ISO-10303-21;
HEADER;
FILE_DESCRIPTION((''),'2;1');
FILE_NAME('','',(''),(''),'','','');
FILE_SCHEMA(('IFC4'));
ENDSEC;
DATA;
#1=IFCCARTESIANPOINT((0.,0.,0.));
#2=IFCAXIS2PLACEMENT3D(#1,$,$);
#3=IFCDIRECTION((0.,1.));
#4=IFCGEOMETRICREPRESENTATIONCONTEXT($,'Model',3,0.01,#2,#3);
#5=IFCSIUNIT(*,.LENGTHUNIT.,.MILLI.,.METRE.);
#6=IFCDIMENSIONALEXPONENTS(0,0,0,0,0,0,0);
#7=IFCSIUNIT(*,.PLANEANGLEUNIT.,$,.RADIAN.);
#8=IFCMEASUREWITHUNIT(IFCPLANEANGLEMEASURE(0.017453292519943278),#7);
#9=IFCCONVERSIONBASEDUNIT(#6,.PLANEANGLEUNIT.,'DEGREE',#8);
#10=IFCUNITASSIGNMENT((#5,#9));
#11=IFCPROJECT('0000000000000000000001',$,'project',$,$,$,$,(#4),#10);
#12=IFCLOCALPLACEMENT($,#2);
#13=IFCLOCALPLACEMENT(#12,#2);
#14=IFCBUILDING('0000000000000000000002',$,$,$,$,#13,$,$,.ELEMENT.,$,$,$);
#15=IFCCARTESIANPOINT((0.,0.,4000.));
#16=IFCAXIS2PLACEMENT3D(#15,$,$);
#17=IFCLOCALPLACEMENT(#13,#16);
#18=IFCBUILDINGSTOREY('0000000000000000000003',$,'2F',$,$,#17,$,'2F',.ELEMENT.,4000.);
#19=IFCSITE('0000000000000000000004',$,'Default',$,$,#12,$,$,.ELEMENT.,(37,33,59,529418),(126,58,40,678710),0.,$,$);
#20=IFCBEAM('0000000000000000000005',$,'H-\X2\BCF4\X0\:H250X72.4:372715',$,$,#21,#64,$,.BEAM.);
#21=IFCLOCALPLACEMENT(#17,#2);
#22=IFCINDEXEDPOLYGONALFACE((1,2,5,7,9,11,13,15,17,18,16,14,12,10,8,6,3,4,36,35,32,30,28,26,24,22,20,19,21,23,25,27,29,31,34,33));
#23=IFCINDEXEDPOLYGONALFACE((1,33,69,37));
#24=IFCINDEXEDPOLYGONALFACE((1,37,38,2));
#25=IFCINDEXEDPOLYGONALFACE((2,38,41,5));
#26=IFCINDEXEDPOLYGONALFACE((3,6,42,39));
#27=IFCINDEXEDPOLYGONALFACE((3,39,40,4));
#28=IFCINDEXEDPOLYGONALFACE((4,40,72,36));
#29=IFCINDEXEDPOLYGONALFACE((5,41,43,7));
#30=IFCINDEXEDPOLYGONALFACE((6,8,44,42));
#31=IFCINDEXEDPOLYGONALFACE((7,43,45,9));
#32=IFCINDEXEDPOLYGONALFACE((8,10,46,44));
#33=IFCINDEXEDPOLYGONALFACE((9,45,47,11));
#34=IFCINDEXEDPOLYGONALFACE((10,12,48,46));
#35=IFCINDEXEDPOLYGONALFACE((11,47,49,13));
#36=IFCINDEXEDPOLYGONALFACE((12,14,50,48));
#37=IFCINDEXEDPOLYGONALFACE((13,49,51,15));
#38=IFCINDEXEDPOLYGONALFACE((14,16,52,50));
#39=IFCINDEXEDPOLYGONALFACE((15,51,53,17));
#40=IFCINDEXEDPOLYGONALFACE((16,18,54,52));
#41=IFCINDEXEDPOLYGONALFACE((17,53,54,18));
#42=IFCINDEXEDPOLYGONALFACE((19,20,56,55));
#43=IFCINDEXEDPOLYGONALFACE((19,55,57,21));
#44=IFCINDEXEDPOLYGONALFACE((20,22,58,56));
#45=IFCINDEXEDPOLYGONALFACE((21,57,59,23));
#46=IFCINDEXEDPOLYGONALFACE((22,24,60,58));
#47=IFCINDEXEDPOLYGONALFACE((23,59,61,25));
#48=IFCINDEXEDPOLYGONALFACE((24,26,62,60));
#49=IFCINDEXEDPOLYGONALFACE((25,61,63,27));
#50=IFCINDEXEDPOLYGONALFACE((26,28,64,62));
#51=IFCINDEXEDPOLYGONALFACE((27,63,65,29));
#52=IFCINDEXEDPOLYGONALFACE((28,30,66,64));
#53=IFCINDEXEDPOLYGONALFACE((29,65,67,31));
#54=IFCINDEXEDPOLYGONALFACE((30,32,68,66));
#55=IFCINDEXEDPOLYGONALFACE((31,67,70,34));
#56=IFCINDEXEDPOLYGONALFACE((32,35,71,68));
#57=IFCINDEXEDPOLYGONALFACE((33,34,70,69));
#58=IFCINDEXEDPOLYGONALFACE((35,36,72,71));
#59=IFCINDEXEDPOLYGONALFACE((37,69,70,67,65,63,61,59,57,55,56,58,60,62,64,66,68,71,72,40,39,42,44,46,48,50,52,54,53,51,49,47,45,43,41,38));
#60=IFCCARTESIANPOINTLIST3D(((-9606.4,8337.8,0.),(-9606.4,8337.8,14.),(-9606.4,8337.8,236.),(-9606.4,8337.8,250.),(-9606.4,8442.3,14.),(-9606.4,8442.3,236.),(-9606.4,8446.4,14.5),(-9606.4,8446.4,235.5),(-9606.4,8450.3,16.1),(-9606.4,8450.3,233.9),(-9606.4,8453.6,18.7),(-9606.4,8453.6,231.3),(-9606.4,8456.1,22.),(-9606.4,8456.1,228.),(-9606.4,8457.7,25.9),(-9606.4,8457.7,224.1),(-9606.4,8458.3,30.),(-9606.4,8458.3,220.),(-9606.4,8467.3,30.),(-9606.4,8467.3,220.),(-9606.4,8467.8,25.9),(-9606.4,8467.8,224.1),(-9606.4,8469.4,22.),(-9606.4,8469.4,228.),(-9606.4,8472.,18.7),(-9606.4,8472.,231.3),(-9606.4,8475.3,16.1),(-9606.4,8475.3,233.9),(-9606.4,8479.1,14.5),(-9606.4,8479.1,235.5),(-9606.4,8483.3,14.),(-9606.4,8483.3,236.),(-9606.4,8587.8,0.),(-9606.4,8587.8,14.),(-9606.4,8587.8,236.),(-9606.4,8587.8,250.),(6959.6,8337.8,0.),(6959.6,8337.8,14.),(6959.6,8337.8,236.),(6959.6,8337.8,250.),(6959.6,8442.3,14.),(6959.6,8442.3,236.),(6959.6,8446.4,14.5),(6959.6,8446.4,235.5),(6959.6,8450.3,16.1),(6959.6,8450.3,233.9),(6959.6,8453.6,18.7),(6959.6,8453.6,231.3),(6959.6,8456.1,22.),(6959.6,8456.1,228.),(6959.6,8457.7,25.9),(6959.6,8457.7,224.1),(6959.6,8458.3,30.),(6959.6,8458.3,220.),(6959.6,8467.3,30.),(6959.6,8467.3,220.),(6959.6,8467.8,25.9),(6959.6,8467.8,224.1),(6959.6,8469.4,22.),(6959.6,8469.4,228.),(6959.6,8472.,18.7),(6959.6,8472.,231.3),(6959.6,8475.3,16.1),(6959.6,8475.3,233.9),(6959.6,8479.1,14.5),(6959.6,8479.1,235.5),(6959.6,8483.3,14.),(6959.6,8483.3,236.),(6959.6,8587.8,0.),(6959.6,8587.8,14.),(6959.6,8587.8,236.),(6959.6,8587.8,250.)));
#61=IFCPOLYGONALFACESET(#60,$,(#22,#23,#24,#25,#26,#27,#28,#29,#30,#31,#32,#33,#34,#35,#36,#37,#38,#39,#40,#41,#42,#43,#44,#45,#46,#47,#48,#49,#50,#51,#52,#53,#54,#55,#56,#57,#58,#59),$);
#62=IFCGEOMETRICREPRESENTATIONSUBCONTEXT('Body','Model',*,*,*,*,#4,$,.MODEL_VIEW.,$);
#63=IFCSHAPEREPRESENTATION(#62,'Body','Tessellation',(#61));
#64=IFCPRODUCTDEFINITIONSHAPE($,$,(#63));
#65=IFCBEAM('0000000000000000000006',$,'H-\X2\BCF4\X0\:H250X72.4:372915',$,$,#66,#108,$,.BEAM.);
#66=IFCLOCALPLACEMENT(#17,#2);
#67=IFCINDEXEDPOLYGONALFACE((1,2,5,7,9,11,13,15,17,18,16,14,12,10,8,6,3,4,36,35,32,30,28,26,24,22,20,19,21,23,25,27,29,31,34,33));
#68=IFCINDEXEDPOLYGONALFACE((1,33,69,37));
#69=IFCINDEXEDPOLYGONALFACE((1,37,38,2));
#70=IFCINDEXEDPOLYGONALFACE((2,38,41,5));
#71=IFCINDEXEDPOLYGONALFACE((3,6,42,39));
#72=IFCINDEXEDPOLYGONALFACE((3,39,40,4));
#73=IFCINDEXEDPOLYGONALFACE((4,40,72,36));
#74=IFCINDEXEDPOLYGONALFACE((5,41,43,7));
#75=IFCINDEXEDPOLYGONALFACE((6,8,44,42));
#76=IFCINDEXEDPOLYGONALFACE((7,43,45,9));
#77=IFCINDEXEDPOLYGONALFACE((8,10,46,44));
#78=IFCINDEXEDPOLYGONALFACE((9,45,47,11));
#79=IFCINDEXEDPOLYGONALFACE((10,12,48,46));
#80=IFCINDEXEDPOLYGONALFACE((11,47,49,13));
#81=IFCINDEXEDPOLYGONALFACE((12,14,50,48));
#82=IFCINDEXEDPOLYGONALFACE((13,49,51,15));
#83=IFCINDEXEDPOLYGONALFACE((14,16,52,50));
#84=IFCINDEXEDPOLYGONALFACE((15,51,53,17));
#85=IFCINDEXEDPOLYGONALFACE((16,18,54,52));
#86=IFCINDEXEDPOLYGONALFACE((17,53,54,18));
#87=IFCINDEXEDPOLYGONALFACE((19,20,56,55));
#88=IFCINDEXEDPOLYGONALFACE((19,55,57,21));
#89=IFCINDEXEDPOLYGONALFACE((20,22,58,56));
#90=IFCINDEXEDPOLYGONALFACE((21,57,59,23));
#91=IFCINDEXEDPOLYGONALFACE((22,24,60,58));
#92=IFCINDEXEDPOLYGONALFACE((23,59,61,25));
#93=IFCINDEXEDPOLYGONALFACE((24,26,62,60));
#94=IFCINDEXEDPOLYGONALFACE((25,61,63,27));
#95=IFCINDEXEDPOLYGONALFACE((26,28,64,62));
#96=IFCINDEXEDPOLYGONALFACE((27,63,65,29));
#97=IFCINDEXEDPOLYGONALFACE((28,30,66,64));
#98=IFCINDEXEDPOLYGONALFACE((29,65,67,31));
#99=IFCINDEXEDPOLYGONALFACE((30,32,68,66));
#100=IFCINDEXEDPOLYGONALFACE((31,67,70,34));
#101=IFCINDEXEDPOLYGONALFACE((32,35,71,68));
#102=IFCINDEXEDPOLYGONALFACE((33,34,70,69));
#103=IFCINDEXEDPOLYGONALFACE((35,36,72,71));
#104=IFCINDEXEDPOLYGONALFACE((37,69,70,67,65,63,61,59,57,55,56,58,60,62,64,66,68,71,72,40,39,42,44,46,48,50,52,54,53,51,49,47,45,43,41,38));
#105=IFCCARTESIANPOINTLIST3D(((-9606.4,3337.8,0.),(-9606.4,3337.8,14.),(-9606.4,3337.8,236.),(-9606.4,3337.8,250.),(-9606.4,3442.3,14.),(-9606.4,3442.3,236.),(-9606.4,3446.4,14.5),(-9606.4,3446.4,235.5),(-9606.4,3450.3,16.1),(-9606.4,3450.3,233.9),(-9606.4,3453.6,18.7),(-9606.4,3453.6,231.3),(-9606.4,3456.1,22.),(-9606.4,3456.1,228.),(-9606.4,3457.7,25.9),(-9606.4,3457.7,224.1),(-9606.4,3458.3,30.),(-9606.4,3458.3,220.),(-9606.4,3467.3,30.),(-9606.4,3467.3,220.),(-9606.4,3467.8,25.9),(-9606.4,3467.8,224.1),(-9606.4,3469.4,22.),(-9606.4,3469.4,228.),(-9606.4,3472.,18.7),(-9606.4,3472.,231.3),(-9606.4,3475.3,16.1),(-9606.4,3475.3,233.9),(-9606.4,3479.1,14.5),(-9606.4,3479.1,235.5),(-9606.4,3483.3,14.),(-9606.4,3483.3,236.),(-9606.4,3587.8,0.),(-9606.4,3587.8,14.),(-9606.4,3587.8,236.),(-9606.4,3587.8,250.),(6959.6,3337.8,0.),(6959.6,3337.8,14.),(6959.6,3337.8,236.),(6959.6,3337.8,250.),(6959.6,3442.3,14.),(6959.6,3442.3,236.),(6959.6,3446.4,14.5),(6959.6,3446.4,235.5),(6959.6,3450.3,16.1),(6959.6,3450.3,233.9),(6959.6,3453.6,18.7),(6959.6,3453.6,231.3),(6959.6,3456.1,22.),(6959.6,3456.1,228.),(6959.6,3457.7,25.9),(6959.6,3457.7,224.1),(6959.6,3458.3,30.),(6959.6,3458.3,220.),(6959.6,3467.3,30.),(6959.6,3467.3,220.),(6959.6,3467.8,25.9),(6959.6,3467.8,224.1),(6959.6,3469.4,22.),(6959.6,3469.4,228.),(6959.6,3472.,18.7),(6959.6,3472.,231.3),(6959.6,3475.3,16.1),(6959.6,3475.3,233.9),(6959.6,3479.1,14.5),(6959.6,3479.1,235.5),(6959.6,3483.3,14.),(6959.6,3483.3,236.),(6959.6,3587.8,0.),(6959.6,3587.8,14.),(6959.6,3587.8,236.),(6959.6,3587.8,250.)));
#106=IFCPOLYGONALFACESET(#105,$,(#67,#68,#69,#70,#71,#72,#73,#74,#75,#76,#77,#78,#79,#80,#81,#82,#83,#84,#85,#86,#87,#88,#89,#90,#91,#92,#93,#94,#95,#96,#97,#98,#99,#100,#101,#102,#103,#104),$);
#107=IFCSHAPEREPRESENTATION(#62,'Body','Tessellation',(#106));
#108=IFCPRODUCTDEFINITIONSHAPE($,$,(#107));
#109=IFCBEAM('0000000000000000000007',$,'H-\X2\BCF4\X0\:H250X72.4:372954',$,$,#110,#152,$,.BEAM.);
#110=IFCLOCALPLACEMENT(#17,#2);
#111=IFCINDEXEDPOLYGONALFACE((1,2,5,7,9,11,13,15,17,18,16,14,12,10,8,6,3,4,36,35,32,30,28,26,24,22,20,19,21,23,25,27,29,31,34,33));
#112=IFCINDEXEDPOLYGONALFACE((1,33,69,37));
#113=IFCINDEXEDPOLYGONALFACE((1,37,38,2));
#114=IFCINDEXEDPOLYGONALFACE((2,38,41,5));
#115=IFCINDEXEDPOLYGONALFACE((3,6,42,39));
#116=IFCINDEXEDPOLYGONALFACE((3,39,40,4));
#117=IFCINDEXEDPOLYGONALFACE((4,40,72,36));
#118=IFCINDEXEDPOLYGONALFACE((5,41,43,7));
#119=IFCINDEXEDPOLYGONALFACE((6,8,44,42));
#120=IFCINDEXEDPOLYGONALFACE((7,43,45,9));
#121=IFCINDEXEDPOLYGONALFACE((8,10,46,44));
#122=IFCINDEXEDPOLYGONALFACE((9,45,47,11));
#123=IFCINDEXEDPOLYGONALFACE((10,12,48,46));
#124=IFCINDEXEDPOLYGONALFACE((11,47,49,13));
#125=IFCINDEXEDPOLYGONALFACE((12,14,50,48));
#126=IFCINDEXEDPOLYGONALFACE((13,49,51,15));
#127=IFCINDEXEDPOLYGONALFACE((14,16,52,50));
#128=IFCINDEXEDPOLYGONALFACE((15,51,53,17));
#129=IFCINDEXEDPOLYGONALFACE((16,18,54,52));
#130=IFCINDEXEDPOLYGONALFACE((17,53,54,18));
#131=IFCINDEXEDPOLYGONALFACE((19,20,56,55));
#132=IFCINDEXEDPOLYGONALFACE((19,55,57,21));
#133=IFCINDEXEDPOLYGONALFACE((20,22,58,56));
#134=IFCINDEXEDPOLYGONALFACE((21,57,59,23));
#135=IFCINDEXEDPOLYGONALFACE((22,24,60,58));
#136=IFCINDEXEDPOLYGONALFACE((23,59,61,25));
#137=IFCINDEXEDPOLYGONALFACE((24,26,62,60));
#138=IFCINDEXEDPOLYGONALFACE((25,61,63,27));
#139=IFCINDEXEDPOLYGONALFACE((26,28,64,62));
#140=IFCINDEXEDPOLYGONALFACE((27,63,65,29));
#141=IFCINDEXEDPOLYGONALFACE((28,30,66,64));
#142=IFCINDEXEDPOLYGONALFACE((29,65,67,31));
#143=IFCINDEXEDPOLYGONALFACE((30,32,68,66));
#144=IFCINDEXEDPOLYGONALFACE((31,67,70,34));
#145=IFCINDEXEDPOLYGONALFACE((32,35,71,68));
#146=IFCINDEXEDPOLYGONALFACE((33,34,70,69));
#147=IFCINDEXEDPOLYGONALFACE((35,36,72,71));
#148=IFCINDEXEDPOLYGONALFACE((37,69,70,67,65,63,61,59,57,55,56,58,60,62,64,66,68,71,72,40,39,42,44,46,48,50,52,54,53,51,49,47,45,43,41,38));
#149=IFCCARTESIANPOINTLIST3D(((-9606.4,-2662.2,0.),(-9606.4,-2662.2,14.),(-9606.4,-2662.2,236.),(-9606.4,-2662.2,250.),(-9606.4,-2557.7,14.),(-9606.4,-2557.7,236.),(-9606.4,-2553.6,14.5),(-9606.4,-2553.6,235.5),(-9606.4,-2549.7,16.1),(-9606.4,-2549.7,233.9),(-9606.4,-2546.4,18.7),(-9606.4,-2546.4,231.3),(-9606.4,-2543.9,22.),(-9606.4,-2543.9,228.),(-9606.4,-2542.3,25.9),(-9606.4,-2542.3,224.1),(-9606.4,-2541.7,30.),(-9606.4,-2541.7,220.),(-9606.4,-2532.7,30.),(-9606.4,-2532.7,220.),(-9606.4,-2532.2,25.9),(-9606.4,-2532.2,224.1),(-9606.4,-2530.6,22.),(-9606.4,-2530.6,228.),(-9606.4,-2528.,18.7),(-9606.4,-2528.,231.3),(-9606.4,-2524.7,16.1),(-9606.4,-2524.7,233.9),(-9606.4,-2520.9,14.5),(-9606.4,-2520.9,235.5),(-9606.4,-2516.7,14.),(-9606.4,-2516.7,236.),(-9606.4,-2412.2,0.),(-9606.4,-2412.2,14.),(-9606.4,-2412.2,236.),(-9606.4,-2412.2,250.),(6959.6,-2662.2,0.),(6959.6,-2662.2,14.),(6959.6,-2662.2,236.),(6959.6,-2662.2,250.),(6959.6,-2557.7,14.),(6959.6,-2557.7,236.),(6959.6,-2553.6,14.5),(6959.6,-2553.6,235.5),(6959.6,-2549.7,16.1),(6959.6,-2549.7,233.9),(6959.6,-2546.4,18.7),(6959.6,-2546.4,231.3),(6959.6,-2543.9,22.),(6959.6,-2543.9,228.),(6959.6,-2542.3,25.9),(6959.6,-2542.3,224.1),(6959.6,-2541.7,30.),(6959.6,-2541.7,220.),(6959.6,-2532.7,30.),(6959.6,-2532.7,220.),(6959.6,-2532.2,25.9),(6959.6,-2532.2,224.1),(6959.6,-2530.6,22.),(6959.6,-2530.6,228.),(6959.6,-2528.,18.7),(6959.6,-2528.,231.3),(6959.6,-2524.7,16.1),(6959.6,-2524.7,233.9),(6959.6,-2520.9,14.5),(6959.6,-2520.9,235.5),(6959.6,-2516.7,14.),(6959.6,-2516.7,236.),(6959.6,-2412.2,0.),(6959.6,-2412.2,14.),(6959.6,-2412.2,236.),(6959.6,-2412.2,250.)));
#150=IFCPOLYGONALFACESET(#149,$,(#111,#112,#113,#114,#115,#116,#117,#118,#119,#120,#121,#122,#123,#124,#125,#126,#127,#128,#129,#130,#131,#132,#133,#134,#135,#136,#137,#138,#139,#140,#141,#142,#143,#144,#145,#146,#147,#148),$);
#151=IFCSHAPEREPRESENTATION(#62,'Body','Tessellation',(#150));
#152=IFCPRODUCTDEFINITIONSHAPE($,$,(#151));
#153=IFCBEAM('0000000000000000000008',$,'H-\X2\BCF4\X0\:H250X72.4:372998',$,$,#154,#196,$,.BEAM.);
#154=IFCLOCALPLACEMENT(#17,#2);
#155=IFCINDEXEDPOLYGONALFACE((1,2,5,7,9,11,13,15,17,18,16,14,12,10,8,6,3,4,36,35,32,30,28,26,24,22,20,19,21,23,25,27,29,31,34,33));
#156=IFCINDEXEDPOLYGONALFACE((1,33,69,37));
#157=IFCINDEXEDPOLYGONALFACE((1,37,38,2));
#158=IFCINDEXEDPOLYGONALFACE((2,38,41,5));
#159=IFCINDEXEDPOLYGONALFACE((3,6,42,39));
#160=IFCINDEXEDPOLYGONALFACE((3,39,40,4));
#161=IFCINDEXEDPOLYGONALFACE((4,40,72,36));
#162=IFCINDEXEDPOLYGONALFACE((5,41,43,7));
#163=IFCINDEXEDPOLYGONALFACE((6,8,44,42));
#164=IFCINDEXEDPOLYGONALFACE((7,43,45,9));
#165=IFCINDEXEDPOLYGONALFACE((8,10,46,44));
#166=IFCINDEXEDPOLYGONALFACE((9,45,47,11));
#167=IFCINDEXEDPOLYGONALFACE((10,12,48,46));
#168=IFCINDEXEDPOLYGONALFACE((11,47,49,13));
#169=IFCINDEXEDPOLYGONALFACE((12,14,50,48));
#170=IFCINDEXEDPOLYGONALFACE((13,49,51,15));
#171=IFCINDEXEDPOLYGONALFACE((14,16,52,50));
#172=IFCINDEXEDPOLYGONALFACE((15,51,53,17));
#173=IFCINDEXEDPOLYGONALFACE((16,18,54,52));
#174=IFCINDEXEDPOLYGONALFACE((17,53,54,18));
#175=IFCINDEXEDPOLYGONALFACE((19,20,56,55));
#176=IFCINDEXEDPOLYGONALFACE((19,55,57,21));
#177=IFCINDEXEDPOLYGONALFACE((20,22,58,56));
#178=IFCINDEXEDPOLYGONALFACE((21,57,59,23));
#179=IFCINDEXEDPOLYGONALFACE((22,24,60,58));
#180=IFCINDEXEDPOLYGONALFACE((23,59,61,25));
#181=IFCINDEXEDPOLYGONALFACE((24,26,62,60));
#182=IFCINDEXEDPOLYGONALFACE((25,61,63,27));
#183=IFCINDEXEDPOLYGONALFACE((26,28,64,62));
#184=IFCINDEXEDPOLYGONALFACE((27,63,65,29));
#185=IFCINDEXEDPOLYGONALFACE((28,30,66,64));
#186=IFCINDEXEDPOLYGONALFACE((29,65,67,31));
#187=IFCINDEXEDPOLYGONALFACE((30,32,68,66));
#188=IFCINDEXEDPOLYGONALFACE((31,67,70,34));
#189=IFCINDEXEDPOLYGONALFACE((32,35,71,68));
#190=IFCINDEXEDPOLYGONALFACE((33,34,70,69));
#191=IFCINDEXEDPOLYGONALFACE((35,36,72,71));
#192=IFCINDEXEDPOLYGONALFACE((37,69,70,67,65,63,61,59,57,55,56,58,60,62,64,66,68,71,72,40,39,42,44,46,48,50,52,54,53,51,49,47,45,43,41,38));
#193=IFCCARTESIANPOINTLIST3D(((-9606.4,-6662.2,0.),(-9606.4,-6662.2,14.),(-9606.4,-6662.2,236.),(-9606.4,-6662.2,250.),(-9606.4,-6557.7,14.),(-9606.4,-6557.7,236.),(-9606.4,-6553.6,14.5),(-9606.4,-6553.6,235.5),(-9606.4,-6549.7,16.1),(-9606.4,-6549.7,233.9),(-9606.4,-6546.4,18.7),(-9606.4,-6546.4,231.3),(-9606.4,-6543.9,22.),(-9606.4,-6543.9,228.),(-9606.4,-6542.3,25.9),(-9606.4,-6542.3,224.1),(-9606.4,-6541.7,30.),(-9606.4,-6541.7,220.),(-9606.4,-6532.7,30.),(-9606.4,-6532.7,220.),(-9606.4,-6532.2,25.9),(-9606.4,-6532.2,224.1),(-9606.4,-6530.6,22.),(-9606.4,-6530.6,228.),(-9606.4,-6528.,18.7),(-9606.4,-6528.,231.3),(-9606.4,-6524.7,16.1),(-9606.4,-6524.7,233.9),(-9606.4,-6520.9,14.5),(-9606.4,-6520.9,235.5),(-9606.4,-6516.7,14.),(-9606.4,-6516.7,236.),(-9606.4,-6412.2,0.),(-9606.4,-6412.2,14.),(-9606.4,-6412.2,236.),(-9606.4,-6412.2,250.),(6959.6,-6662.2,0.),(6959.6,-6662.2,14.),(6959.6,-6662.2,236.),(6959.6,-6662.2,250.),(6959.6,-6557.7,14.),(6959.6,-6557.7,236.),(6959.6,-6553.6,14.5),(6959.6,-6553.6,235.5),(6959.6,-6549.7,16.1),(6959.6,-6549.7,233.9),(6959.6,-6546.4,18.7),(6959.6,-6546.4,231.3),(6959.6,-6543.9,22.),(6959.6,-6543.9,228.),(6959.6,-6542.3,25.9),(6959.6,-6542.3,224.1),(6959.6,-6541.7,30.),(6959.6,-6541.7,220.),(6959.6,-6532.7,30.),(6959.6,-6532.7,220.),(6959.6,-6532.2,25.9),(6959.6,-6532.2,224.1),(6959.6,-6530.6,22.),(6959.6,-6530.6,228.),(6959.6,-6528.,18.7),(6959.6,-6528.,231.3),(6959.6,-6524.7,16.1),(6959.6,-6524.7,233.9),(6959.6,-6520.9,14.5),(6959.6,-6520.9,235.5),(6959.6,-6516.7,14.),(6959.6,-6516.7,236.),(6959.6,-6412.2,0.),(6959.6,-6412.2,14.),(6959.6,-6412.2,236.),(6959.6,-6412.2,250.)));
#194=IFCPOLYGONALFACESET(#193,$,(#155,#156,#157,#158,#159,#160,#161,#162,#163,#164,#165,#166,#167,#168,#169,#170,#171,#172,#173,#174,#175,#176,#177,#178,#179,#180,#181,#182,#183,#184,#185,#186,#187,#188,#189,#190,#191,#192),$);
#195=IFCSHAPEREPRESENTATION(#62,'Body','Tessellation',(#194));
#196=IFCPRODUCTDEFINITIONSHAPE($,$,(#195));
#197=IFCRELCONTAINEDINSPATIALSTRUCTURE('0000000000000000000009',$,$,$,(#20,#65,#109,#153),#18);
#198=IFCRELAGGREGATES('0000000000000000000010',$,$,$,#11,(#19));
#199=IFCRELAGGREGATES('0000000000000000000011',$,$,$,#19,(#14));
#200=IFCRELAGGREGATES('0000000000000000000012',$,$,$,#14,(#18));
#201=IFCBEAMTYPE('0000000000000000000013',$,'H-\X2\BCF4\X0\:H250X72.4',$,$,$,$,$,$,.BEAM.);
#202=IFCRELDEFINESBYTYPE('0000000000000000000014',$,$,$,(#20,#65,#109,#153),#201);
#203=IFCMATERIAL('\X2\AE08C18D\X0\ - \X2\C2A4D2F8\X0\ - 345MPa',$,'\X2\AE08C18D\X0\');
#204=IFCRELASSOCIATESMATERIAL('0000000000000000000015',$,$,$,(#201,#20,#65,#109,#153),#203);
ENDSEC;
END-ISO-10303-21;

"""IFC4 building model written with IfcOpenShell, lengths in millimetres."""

from ifc_helpers import new_model, entity, si_unit, converted_unit, direction, frame, origin, place, context, subcontext, project, spatial, line, arc, indexed_curve, outline, extrude, source, transform, mapped, material, type_object, type_shapes, element, save


model = new_model("IFC4")

# Units and contexts
model_context = context("Model", 3, precision=0.01, world=origin(), true_north=direction((0.0, 1.0)))
body_context = subcontext(model_context, "Body", "Model", "MODEL_VIEW")
ifc_project = project(units=[si_unit("LENGTHUNIT", "METRE", prefix="MILLI"), converted_unit("PLANEANGLEUNIT", "DEGREE", entity("IfcPlaneAngleMeasure", 0.017453292519943278), si_unit("PLANEANGLEUNIT", "RADIAN"), dimensions=[0, 0, 0, 0, 0, 0, 0])], contexts=[model_context])

# Site, building, storey
site_placement = place(None, origin())
site = spatial("IfcSite", under=ifc_project, at=site_placement, Name="Default", CompositionType="ELEMENT", RefLatitude=(37, 33, 59, 529418), RefLongitude=(126, 58, 40, 678710), RefElevation=0.0)
building_placement = place(site_placement, origin())
building = spatial("IfcBuilding", under=site, at=building_placement, CompositionType="ELEMENT")
storey_placement = place(building_placement, frame((0.0, 0.0, 4000.0)))
storey = spatial("IfcBuildingStorey", under=building, at=storey_placement, Name="2F", LongName="2F", CompositionType="ELEMENT", Elevation=4000.0)

# Shared definitions
ifc_material = material(Name="금속 - 스틸 - 345MPa", Category="금속")

# Beams
beam_type_1 = type_object("IfcBeamType", Name="H-보:H250X72.4", PredefinedType="BEAM", material=ifc_material)
shared_shape_1 = source(origin(), body_context, "Body", "SweptSolid", [
    extrude(outline(indexed_curve([(-125.0, -111.0), (-125.0, -125.0), (125.0, -125.0), (125.0, -111.0), (20.5, -111.0), (9.2, -106.3), (4.5, -95.0), (4.5, 95.0), (9.2, 106.3), (20.5, 111.0), (125.0, 111.0), (125.0, 125.0), (-125.0, 125.0), (-125.0, 111.0), (-20.5, 111.0), (-9.2, 106.3), (-4.5, 95.0), (-4.5, -95.0), (-9.2, -106.3), (-20.5, -111.0)], segments=[line(1, 2, 3, 4, 5), arc(5, 6, 7), line(7, 8), arc(8, 9, 10), line(10, 11, 12, 13, 14, 15), arc(15, 16, 17), line(17, 18), arc(18, 19, 20), line(20, 1)], self_intersect=False)), frame((-8283.0, 0.0, 0.0), z_axis=(-1.0, 0.0, 0.0), x_axis=(0.0, -1.0, 0.0)), (0.0, 0.0, -1.0), 16566.0),
])
type_shapes(beam_type_1, [shared_shape_1])
for number, where, name in (
    (1, (-1323.4, 8462.8, 125.0), "H-보:H250X72.4:372715"),
    (2, (-1323.4, 3462.8, 125.0), "H-보:H250X72.4:372915"),
    (3, (-1323.4, -2537.2, 125.0), "H-보:H250X72.4:372954"),
    (4, (-1323.4, -6537.2, 125.0), "H-보:H250X72.4:372998"),
):
    element("IfcBeam", number, at=place(storey_placement, frame(where)), inside=storey, type_object=beam_type_1, material=ifc_material, Name=name, PredefinedType="BEAM", context=body_context, shape_type="MappedRepresentation", body=[
        mapped(shared_shape_1, transform((0.0, 0.0, 0.0), scale=1.0)),
    ])

save(model, "model.ifc")
